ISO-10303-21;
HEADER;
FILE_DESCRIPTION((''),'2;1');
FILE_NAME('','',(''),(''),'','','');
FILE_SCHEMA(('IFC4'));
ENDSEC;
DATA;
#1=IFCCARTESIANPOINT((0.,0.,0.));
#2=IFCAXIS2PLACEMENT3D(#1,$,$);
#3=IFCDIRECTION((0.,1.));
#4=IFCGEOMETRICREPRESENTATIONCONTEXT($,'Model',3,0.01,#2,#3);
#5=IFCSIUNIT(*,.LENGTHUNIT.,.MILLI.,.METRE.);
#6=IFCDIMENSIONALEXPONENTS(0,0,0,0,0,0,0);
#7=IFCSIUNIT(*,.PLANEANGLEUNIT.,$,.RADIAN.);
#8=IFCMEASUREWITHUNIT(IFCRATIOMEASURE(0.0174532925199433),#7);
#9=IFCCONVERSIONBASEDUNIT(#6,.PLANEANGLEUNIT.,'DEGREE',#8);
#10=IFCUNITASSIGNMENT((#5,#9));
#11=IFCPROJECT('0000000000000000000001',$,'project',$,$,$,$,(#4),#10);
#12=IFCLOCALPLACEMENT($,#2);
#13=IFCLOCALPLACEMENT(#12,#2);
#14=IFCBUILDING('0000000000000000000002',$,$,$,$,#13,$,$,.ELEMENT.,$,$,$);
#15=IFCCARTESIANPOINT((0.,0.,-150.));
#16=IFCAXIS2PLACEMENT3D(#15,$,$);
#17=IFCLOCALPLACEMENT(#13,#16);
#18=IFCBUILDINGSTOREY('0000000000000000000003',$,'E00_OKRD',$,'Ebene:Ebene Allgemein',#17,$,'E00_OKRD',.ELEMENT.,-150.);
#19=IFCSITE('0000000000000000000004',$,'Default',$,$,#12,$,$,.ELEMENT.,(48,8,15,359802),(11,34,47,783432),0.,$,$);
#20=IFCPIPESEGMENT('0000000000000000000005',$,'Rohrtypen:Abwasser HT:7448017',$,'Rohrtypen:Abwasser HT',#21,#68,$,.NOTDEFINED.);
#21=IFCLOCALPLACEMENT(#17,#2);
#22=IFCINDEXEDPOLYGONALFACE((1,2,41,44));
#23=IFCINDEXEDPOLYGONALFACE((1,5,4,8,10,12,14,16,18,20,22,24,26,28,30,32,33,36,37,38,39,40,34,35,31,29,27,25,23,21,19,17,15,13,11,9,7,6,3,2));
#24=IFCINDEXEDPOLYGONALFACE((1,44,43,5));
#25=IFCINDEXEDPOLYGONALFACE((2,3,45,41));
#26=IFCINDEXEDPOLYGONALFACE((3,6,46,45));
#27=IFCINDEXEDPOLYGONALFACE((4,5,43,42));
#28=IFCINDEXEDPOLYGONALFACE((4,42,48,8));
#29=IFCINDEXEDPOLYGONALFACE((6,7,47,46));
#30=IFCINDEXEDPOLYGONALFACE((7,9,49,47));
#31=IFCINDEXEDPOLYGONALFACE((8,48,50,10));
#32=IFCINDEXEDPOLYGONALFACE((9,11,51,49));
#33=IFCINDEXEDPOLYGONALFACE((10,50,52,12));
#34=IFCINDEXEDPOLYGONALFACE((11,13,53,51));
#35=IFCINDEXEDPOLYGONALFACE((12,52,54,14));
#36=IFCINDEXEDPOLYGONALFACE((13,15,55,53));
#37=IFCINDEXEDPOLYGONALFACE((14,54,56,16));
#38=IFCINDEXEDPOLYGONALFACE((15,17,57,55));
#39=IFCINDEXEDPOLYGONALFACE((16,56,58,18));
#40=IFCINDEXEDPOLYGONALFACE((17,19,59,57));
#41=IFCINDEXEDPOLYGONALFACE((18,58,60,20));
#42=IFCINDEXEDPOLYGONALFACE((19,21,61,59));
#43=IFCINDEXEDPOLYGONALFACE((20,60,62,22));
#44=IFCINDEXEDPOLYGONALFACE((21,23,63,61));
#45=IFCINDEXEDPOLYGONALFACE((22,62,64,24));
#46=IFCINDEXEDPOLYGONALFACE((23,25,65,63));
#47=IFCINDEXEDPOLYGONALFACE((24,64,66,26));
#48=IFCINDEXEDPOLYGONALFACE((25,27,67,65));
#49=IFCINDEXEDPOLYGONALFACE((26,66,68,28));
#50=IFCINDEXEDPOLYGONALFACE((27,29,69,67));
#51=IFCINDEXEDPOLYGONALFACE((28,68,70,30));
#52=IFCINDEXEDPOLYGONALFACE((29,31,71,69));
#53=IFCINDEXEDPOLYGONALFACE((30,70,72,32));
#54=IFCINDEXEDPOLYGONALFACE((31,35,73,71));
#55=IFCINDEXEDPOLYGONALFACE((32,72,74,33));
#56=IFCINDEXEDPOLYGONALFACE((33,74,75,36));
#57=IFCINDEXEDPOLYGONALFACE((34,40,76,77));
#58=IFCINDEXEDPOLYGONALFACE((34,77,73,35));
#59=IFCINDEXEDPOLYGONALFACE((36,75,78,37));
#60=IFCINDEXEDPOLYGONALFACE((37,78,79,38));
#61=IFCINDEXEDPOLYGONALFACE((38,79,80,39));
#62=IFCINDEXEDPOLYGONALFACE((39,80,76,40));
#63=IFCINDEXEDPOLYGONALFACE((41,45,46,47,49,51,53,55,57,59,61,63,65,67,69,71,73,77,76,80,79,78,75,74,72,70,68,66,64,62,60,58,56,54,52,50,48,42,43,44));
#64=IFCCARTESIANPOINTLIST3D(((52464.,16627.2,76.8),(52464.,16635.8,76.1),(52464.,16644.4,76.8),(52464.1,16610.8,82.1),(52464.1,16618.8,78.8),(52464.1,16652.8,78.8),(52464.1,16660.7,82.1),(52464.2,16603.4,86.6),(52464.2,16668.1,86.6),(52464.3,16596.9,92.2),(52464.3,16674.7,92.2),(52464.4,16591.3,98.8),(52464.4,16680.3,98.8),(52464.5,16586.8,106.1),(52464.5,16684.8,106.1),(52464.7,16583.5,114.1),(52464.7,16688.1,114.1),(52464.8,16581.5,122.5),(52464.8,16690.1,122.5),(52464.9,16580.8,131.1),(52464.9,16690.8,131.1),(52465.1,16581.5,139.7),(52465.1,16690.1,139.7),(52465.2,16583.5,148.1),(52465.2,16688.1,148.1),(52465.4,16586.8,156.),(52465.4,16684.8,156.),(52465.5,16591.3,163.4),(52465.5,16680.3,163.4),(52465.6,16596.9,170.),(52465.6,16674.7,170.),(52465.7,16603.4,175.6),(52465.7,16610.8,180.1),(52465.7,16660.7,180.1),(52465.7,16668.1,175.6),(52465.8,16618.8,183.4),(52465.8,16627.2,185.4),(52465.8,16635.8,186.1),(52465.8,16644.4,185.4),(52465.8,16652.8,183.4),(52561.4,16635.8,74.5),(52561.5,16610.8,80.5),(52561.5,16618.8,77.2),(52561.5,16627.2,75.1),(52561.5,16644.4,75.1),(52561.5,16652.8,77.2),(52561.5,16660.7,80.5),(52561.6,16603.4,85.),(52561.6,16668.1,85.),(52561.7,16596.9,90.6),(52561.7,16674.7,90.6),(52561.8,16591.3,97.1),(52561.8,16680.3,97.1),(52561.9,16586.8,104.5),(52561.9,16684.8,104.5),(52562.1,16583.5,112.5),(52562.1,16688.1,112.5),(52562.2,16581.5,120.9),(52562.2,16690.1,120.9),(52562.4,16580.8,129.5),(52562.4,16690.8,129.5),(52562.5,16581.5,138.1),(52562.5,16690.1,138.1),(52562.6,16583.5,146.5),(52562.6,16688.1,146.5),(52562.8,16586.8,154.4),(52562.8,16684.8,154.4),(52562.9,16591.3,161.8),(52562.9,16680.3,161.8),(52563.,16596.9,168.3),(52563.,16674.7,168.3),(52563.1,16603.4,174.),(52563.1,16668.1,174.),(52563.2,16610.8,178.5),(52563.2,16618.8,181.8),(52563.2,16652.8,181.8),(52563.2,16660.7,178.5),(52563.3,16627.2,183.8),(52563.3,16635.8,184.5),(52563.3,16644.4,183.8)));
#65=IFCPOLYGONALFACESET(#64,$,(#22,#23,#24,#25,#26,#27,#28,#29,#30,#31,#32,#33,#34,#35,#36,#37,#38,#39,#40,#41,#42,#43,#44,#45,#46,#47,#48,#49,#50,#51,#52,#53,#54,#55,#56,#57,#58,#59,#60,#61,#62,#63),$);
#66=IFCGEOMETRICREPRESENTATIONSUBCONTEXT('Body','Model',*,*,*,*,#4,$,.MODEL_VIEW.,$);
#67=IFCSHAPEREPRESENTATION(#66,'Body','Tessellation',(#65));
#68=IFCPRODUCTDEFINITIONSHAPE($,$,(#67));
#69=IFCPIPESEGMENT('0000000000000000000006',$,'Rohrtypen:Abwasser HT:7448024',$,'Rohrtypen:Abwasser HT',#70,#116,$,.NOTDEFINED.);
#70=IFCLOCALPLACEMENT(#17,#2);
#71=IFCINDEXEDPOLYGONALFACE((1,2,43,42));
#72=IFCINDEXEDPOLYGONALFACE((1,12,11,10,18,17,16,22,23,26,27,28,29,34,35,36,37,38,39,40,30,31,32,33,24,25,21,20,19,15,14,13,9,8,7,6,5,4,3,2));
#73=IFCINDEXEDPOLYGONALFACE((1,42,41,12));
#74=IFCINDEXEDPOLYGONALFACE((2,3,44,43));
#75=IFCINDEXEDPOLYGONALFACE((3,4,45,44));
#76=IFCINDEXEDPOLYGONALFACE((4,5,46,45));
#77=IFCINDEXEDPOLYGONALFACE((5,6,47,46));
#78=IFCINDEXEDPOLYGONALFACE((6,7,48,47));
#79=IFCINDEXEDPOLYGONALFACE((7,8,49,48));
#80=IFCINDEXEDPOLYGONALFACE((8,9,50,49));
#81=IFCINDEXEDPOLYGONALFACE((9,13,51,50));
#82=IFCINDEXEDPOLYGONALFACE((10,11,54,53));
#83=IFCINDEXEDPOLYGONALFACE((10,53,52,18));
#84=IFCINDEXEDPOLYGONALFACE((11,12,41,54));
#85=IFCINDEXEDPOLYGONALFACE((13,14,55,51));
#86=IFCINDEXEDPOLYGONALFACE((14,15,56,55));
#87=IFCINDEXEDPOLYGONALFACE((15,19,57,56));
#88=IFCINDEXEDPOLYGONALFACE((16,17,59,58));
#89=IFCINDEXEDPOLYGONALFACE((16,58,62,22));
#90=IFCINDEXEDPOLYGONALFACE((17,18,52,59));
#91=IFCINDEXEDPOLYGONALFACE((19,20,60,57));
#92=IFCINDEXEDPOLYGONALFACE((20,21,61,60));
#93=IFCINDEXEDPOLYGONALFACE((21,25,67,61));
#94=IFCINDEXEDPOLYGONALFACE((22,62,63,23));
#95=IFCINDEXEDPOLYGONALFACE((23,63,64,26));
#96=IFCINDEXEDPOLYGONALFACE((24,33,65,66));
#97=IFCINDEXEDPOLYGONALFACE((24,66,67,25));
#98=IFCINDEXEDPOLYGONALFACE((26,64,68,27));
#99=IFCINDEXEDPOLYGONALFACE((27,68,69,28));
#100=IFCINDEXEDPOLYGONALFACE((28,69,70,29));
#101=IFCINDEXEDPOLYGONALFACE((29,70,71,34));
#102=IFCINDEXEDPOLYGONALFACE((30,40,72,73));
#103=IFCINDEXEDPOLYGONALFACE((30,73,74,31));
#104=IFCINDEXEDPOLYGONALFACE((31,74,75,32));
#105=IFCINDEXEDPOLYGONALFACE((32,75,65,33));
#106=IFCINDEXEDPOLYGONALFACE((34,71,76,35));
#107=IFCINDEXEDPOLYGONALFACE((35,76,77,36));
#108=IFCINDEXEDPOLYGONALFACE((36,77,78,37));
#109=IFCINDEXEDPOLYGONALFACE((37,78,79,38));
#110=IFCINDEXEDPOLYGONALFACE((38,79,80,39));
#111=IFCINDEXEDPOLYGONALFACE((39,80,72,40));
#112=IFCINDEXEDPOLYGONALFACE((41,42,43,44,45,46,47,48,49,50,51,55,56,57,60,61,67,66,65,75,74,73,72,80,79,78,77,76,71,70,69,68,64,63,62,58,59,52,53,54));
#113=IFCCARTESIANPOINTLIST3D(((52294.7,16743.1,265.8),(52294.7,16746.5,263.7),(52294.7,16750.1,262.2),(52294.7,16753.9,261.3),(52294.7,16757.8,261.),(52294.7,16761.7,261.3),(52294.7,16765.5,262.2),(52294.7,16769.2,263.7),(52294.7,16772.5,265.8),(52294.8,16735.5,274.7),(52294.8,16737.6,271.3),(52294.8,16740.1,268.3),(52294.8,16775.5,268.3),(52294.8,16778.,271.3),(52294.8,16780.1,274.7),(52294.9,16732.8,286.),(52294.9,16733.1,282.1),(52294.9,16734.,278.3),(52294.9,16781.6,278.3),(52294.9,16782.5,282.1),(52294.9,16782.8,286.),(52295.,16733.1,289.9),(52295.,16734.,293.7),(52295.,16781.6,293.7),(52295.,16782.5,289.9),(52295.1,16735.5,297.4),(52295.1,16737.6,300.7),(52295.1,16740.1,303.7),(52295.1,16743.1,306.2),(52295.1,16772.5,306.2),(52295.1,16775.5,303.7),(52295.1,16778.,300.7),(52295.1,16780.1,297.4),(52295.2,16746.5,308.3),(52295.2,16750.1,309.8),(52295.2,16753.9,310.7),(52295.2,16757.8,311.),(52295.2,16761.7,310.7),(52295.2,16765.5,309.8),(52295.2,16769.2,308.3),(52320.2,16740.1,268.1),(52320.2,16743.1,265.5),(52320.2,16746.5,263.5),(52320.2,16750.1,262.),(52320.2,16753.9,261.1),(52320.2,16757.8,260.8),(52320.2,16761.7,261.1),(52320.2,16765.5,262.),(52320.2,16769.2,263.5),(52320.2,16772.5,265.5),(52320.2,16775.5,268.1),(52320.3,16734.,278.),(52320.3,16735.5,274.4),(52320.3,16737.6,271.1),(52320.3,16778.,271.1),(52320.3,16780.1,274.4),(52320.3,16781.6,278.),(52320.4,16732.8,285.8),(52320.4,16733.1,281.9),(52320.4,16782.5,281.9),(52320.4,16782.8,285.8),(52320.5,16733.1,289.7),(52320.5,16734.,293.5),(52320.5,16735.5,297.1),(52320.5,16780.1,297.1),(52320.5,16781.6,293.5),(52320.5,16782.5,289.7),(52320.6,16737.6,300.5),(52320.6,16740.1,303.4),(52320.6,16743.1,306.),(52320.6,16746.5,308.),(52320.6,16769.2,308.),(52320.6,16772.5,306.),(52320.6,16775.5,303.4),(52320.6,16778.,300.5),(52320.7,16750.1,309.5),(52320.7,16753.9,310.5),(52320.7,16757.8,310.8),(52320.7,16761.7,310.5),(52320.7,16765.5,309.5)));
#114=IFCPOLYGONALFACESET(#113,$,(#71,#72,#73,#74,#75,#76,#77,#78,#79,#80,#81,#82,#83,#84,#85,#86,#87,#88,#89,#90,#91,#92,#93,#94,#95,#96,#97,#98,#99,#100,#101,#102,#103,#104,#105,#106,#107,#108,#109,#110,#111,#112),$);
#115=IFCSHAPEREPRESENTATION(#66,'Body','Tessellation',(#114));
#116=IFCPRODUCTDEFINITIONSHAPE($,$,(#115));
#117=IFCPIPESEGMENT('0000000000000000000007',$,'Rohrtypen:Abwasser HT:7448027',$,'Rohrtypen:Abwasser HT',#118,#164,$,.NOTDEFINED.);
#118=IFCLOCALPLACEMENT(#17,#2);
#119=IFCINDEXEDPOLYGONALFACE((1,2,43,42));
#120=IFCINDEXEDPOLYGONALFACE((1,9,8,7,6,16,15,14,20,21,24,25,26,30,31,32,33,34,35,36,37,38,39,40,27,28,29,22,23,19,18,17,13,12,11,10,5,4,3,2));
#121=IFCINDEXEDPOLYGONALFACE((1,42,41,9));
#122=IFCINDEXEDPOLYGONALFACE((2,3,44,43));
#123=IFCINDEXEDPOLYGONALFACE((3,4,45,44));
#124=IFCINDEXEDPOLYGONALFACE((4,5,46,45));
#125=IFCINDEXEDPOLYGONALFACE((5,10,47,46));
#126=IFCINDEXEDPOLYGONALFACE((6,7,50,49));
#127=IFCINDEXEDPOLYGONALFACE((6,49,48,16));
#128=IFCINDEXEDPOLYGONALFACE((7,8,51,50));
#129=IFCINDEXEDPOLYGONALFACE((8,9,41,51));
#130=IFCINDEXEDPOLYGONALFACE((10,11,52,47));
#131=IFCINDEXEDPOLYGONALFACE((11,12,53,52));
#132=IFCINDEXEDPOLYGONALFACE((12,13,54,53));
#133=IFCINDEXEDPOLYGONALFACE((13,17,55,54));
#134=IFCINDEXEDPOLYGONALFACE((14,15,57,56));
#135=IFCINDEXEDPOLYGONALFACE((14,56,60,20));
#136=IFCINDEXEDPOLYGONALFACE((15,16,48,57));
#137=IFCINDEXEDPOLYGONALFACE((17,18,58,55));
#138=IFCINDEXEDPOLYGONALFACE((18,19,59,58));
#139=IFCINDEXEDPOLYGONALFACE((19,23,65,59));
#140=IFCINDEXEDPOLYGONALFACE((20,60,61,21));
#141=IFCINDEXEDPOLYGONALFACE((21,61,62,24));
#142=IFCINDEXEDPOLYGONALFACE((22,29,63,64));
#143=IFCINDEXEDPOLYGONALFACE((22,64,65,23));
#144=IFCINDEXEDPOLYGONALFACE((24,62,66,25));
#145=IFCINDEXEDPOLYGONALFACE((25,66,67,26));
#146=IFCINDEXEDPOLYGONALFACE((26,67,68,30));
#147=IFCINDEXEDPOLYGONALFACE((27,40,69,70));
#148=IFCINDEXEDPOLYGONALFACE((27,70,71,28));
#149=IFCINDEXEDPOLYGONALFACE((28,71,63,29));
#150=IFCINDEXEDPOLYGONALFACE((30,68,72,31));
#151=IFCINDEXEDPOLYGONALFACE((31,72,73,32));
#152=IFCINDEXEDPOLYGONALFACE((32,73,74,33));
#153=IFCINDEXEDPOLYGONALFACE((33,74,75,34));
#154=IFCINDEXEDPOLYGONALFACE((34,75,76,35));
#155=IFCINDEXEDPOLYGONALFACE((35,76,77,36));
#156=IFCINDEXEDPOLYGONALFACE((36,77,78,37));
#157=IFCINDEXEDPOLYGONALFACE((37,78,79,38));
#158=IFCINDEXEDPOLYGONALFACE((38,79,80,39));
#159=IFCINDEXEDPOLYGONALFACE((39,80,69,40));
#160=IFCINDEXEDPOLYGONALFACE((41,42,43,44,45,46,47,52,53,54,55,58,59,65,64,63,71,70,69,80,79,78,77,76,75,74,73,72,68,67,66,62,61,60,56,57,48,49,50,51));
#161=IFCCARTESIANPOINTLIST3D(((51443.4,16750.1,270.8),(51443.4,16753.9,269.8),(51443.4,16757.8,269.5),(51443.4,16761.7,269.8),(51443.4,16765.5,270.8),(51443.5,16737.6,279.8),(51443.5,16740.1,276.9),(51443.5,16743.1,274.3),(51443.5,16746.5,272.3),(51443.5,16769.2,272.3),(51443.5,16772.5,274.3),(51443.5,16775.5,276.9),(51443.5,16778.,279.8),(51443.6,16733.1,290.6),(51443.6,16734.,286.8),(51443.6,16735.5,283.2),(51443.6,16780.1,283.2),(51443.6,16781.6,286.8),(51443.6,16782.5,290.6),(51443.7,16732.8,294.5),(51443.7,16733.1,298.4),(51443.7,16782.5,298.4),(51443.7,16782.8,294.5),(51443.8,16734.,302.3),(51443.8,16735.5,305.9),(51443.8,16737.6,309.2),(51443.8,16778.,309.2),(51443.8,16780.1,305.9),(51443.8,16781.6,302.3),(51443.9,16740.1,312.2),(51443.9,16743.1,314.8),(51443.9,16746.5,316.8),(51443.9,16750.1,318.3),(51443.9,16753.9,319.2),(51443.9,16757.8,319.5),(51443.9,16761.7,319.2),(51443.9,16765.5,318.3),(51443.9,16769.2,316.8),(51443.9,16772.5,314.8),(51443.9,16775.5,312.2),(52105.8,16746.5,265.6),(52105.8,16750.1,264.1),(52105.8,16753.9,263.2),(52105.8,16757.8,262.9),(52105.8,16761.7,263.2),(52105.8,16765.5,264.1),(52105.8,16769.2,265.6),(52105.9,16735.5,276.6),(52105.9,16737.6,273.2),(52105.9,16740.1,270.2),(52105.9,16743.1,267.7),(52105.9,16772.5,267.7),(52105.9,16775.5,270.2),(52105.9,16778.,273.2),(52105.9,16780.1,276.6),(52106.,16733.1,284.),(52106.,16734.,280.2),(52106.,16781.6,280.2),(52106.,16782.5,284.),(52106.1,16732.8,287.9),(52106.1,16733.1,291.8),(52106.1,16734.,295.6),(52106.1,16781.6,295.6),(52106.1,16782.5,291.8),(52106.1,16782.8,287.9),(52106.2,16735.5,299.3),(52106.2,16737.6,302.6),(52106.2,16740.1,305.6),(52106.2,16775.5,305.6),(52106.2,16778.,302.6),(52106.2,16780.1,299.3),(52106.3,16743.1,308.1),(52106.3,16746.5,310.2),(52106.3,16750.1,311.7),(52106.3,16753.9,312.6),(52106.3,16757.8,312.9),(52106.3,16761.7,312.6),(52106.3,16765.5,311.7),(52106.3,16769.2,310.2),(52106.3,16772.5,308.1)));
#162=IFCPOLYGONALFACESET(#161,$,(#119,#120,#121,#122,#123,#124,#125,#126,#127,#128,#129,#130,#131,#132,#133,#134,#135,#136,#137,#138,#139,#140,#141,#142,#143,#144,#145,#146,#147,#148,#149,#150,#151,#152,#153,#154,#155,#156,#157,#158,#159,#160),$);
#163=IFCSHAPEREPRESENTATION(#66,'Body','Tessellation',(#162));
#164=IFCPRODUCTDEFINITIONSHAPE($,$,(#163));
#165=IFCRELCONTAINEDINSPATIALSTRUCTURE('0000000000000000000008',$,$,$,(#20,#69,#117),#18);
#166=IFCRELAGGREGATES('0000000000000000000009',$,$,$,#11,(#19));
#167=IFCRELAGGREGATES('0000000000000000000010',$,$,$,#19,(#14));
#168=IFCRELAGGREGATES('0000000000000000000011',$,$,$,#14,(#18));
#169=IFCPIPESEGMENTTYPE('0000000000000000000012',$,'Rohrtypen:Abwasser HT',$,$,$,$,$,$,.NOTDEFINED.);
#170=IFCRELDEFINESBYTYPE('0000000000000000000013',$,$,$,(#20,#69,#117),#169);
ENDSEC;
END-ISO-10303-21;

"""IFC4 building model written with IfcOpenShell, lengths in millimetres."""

from ifc_helpers import new_model, entity, si_unit, converted_unit, direction, frame, origin, place, context, subcontext, project, spatial, indexed_curve, outline, extrude, type_object, element, save


model = new_model("IFC4")

# Units and contexts
model_context = context("Model", 3, precision=0.01, world=origin(), true_north=direction((0.0, 1.0)))
body_context = subcontext(model_context, "Body", "Model", "MODEL_VIEW")
ifc_project = project(units=[si_unit("LENGTHUNIT", "METRE", prefix="MILLI"), converted_unit("PLANEANGLEUNIT", "DEGREE", entity("IfcRatioMeasure", 0.0174532925199433), si_unit("PLANEANGLEUNIT", "RADIAN"), dimensions=[0, 0, 0, 0, 0, 0, 0])], contexts=[model_context])

# Site, building, storey
site_placement = place(None, origin())
site = spatial("IfcSite", under=ifc_project, at=site_placement, Name="Default", CompositionType="ELEMENT", RefLatitude=(48, 8, 15, 359802), RefLongitude=(11, 34, 47, 783432), RefElevation=0.0)
building_placement = place(site_placement, origin())
building = spatial("IfcBuilding", under=site, at=building_placement, CompositionType="ELEMENT")
storey_placement = place(building_placement, frame((0.0, 0.0, -150.0)))
storey = spatial("IfcBuildingStorey", under=building, at=storey_placement, Name="E00_OKRD", ObjectType="Ebene:Ebene Allgemein", LongName="E00_OKRD", CompositionType="ELEMENT", Elevation=-150.0)

# Pipe segments
pipe_segment_type_1 = type_object("IfcPipeSegmentType", Name="Rohrtypen:Abwasser HT", PredefinedType="NOTDEFINED")
pipe_segment_1_placement = place(storey_placement, origin())
element("IfcPipeSegment", 1, at=pipe_segment_1_placement, inside=storey, type_object=pipe_segment_type_1, Name="Rohrtypen:Abwasser HT:7448017", ObjectType="Rohrtypen:Abwasser HT", PredefinedType="NOTDEFINED", context=body_context, shape_type="SweptSolid", body=[
    extrude(outline(indexed_curve([(55.0, 0.0), (54.3, 8.6), (52.3, 17.0), (49.0, 25.0), (44.5, 32.3), (38.9, 38.9), (32.3, 44.5), (25.0, 49.0), (17.0, 52.3), (8.6, 54.3), (0.0, 55.0), (-8.6, 54.3), (-17.0, 52.3), (-25.0, 49.0), (-32.3, 44.5), (-38.9, 38.9), (-44.5, 32.3), (-49.0, 25.0), (-52.3, 17.0), (-54.3, 8.6), (-55.0, 0.0), (-54.3, -8.6), (-52.3, -17.0), (-49.0, -25.0), (-44.5, -32.3), (-38.9, -38.9), (-32.3, -44.5), (-25.0, -49.0), (-17.0, -52.3), (-8.6, -54.3), (0.0, -55.0), (8.6, -54.3), (17.0, -52.3), (25.0, -49.0), (32.3, -44.5), (38.9, -38.9), (44.5, -32.3), (49.0, -25.0), (52.3, -17.0), (54.3, -8.6), (55.0, 0.0)], self_intersect=False)), frame((52562.4, 16635.8, 129.5), z_axis=(-0.999862, 0.0, 0.016604), x_axis=(0.0, 1.0, 0.0)), (0.0, 0.0, 1.0), 97.4),
])
pipe_segment_2_placement = place(storey_placement, origin())
element("IfcPipeSegment", 2, at=pipe_segment_2_placement, inside=storey, type_object=pipe_segment_type_1, Name="Rohrtypen:Abwasser HT:7448024", ObjectType="Rohrtypen:Abwasser HT", PredefinedType="NOTDEFINED", context=body_context, shape_type="SweptSolid", body=[
    extrude(outline(indexed_curve([(25.0, 0.0), (24.7, 3.9), (23.8, 7.7), (22.3, 11.3), (20.2, 14.7), (17.7, 17.7), (14.7, 20.2), (11.3, 22.3), (7.7, 23.8), (3.9, 24.7), (0.0, 25.0), (-3.9, 24.7), (-7.7, 23.8), (-11.3, 22.3), (-14.7, 20.2), (-17.7, 17.7), (-20.2, 14.7), (-22.3, 11.3), (-23.8, 7.7), (-24.7, 3.9), (-25.0, 0.0), (-24.7, -3.9), (-23.8, -7.7), (-22.3, -11.3), (-20.2, -14.7), (-17.7, -17.7), (-14.7, -20.2), (-11.3, -22.3), (-7.7, -23.8), (-3.9, -24.7), (0.0, -25.0), (3.9, -24.7), (7.7, -23.8), (11.3, -22.3), (14.7, -20.2), (17.7, -17.7), (20.2, -14.7), (22.3, -11.3), (23.8, -7.7), (24.7, -3.9), (25.0, 0.0)], self_intersect=False)), frame((52294.9, 16757.8, 286.0), z_axis=(0.99995, 0.0, -0.01), x_axis=(0.0, -1.0, 0.0)), (0.0, 0.0, 1.0), 25.5),
])
pipe_segment_3_placement = place(storey_placement, origin())
element("IfcPipeSegment", 3, at=pipe_segment_3_placement, inside=storey, type_object=pipe_segment_type_1, Name="Rohrtypen:Abwasser HT:7448027", ObjectType="Rohrtypen:Abwasser HT", PredefinedType="NOTDEFINED", context=body_context, shape_type="SweptSolid", body=[
    extrude(outline(indexed_curve([(25.0, 0.0), (24.7, 3.9), (23.8, 7.7), (22.3, 11.3), (20.2, 14.7), (17.7, 17.7), (14.7, 20.2), (11.3, 22.3), (7.7, 23.8), (3.9, 24.7), (0.0, 25.0), (-3.9, 24.7), (-7.7, 23.8), (-11.3, 22.3), (-14.7, 20.2), (-17.7, 17.7), (-20.2, 14.7), (-22.3, 11.3), (-23.8, 7.7), (-24.7, 3.9), (-25.0, 0.0), (-24.7, -3.9), (-23.8, -7.7), (-22.3, -11.3), (-20.2, -14.7), (-17.7, -17.7), (-14.7, -20.2), (-11.3, -22.3), (-7.7, -23.8), (-3.9, -24.7), (0.0, -25.0), (3.9, -24.7), (7.7, -23.8), (11.3, -22.3), (14.7, -20.2), (17.7, -17.7), (20.2, -14.7), (22.3, -11.3), (23.8, -7.7), (24.7, -3.9), (25.0, 0.0)], self_intersect=False)), frame((51443.7, 16757.8, 294.5), z_axis=(0.99995, 0.0, -0.01), x_axis=(0.0, -1.0, 0.0)), (0.0, 0.0, 1.0), 662.4),
])

save(model, "model.ifc")
